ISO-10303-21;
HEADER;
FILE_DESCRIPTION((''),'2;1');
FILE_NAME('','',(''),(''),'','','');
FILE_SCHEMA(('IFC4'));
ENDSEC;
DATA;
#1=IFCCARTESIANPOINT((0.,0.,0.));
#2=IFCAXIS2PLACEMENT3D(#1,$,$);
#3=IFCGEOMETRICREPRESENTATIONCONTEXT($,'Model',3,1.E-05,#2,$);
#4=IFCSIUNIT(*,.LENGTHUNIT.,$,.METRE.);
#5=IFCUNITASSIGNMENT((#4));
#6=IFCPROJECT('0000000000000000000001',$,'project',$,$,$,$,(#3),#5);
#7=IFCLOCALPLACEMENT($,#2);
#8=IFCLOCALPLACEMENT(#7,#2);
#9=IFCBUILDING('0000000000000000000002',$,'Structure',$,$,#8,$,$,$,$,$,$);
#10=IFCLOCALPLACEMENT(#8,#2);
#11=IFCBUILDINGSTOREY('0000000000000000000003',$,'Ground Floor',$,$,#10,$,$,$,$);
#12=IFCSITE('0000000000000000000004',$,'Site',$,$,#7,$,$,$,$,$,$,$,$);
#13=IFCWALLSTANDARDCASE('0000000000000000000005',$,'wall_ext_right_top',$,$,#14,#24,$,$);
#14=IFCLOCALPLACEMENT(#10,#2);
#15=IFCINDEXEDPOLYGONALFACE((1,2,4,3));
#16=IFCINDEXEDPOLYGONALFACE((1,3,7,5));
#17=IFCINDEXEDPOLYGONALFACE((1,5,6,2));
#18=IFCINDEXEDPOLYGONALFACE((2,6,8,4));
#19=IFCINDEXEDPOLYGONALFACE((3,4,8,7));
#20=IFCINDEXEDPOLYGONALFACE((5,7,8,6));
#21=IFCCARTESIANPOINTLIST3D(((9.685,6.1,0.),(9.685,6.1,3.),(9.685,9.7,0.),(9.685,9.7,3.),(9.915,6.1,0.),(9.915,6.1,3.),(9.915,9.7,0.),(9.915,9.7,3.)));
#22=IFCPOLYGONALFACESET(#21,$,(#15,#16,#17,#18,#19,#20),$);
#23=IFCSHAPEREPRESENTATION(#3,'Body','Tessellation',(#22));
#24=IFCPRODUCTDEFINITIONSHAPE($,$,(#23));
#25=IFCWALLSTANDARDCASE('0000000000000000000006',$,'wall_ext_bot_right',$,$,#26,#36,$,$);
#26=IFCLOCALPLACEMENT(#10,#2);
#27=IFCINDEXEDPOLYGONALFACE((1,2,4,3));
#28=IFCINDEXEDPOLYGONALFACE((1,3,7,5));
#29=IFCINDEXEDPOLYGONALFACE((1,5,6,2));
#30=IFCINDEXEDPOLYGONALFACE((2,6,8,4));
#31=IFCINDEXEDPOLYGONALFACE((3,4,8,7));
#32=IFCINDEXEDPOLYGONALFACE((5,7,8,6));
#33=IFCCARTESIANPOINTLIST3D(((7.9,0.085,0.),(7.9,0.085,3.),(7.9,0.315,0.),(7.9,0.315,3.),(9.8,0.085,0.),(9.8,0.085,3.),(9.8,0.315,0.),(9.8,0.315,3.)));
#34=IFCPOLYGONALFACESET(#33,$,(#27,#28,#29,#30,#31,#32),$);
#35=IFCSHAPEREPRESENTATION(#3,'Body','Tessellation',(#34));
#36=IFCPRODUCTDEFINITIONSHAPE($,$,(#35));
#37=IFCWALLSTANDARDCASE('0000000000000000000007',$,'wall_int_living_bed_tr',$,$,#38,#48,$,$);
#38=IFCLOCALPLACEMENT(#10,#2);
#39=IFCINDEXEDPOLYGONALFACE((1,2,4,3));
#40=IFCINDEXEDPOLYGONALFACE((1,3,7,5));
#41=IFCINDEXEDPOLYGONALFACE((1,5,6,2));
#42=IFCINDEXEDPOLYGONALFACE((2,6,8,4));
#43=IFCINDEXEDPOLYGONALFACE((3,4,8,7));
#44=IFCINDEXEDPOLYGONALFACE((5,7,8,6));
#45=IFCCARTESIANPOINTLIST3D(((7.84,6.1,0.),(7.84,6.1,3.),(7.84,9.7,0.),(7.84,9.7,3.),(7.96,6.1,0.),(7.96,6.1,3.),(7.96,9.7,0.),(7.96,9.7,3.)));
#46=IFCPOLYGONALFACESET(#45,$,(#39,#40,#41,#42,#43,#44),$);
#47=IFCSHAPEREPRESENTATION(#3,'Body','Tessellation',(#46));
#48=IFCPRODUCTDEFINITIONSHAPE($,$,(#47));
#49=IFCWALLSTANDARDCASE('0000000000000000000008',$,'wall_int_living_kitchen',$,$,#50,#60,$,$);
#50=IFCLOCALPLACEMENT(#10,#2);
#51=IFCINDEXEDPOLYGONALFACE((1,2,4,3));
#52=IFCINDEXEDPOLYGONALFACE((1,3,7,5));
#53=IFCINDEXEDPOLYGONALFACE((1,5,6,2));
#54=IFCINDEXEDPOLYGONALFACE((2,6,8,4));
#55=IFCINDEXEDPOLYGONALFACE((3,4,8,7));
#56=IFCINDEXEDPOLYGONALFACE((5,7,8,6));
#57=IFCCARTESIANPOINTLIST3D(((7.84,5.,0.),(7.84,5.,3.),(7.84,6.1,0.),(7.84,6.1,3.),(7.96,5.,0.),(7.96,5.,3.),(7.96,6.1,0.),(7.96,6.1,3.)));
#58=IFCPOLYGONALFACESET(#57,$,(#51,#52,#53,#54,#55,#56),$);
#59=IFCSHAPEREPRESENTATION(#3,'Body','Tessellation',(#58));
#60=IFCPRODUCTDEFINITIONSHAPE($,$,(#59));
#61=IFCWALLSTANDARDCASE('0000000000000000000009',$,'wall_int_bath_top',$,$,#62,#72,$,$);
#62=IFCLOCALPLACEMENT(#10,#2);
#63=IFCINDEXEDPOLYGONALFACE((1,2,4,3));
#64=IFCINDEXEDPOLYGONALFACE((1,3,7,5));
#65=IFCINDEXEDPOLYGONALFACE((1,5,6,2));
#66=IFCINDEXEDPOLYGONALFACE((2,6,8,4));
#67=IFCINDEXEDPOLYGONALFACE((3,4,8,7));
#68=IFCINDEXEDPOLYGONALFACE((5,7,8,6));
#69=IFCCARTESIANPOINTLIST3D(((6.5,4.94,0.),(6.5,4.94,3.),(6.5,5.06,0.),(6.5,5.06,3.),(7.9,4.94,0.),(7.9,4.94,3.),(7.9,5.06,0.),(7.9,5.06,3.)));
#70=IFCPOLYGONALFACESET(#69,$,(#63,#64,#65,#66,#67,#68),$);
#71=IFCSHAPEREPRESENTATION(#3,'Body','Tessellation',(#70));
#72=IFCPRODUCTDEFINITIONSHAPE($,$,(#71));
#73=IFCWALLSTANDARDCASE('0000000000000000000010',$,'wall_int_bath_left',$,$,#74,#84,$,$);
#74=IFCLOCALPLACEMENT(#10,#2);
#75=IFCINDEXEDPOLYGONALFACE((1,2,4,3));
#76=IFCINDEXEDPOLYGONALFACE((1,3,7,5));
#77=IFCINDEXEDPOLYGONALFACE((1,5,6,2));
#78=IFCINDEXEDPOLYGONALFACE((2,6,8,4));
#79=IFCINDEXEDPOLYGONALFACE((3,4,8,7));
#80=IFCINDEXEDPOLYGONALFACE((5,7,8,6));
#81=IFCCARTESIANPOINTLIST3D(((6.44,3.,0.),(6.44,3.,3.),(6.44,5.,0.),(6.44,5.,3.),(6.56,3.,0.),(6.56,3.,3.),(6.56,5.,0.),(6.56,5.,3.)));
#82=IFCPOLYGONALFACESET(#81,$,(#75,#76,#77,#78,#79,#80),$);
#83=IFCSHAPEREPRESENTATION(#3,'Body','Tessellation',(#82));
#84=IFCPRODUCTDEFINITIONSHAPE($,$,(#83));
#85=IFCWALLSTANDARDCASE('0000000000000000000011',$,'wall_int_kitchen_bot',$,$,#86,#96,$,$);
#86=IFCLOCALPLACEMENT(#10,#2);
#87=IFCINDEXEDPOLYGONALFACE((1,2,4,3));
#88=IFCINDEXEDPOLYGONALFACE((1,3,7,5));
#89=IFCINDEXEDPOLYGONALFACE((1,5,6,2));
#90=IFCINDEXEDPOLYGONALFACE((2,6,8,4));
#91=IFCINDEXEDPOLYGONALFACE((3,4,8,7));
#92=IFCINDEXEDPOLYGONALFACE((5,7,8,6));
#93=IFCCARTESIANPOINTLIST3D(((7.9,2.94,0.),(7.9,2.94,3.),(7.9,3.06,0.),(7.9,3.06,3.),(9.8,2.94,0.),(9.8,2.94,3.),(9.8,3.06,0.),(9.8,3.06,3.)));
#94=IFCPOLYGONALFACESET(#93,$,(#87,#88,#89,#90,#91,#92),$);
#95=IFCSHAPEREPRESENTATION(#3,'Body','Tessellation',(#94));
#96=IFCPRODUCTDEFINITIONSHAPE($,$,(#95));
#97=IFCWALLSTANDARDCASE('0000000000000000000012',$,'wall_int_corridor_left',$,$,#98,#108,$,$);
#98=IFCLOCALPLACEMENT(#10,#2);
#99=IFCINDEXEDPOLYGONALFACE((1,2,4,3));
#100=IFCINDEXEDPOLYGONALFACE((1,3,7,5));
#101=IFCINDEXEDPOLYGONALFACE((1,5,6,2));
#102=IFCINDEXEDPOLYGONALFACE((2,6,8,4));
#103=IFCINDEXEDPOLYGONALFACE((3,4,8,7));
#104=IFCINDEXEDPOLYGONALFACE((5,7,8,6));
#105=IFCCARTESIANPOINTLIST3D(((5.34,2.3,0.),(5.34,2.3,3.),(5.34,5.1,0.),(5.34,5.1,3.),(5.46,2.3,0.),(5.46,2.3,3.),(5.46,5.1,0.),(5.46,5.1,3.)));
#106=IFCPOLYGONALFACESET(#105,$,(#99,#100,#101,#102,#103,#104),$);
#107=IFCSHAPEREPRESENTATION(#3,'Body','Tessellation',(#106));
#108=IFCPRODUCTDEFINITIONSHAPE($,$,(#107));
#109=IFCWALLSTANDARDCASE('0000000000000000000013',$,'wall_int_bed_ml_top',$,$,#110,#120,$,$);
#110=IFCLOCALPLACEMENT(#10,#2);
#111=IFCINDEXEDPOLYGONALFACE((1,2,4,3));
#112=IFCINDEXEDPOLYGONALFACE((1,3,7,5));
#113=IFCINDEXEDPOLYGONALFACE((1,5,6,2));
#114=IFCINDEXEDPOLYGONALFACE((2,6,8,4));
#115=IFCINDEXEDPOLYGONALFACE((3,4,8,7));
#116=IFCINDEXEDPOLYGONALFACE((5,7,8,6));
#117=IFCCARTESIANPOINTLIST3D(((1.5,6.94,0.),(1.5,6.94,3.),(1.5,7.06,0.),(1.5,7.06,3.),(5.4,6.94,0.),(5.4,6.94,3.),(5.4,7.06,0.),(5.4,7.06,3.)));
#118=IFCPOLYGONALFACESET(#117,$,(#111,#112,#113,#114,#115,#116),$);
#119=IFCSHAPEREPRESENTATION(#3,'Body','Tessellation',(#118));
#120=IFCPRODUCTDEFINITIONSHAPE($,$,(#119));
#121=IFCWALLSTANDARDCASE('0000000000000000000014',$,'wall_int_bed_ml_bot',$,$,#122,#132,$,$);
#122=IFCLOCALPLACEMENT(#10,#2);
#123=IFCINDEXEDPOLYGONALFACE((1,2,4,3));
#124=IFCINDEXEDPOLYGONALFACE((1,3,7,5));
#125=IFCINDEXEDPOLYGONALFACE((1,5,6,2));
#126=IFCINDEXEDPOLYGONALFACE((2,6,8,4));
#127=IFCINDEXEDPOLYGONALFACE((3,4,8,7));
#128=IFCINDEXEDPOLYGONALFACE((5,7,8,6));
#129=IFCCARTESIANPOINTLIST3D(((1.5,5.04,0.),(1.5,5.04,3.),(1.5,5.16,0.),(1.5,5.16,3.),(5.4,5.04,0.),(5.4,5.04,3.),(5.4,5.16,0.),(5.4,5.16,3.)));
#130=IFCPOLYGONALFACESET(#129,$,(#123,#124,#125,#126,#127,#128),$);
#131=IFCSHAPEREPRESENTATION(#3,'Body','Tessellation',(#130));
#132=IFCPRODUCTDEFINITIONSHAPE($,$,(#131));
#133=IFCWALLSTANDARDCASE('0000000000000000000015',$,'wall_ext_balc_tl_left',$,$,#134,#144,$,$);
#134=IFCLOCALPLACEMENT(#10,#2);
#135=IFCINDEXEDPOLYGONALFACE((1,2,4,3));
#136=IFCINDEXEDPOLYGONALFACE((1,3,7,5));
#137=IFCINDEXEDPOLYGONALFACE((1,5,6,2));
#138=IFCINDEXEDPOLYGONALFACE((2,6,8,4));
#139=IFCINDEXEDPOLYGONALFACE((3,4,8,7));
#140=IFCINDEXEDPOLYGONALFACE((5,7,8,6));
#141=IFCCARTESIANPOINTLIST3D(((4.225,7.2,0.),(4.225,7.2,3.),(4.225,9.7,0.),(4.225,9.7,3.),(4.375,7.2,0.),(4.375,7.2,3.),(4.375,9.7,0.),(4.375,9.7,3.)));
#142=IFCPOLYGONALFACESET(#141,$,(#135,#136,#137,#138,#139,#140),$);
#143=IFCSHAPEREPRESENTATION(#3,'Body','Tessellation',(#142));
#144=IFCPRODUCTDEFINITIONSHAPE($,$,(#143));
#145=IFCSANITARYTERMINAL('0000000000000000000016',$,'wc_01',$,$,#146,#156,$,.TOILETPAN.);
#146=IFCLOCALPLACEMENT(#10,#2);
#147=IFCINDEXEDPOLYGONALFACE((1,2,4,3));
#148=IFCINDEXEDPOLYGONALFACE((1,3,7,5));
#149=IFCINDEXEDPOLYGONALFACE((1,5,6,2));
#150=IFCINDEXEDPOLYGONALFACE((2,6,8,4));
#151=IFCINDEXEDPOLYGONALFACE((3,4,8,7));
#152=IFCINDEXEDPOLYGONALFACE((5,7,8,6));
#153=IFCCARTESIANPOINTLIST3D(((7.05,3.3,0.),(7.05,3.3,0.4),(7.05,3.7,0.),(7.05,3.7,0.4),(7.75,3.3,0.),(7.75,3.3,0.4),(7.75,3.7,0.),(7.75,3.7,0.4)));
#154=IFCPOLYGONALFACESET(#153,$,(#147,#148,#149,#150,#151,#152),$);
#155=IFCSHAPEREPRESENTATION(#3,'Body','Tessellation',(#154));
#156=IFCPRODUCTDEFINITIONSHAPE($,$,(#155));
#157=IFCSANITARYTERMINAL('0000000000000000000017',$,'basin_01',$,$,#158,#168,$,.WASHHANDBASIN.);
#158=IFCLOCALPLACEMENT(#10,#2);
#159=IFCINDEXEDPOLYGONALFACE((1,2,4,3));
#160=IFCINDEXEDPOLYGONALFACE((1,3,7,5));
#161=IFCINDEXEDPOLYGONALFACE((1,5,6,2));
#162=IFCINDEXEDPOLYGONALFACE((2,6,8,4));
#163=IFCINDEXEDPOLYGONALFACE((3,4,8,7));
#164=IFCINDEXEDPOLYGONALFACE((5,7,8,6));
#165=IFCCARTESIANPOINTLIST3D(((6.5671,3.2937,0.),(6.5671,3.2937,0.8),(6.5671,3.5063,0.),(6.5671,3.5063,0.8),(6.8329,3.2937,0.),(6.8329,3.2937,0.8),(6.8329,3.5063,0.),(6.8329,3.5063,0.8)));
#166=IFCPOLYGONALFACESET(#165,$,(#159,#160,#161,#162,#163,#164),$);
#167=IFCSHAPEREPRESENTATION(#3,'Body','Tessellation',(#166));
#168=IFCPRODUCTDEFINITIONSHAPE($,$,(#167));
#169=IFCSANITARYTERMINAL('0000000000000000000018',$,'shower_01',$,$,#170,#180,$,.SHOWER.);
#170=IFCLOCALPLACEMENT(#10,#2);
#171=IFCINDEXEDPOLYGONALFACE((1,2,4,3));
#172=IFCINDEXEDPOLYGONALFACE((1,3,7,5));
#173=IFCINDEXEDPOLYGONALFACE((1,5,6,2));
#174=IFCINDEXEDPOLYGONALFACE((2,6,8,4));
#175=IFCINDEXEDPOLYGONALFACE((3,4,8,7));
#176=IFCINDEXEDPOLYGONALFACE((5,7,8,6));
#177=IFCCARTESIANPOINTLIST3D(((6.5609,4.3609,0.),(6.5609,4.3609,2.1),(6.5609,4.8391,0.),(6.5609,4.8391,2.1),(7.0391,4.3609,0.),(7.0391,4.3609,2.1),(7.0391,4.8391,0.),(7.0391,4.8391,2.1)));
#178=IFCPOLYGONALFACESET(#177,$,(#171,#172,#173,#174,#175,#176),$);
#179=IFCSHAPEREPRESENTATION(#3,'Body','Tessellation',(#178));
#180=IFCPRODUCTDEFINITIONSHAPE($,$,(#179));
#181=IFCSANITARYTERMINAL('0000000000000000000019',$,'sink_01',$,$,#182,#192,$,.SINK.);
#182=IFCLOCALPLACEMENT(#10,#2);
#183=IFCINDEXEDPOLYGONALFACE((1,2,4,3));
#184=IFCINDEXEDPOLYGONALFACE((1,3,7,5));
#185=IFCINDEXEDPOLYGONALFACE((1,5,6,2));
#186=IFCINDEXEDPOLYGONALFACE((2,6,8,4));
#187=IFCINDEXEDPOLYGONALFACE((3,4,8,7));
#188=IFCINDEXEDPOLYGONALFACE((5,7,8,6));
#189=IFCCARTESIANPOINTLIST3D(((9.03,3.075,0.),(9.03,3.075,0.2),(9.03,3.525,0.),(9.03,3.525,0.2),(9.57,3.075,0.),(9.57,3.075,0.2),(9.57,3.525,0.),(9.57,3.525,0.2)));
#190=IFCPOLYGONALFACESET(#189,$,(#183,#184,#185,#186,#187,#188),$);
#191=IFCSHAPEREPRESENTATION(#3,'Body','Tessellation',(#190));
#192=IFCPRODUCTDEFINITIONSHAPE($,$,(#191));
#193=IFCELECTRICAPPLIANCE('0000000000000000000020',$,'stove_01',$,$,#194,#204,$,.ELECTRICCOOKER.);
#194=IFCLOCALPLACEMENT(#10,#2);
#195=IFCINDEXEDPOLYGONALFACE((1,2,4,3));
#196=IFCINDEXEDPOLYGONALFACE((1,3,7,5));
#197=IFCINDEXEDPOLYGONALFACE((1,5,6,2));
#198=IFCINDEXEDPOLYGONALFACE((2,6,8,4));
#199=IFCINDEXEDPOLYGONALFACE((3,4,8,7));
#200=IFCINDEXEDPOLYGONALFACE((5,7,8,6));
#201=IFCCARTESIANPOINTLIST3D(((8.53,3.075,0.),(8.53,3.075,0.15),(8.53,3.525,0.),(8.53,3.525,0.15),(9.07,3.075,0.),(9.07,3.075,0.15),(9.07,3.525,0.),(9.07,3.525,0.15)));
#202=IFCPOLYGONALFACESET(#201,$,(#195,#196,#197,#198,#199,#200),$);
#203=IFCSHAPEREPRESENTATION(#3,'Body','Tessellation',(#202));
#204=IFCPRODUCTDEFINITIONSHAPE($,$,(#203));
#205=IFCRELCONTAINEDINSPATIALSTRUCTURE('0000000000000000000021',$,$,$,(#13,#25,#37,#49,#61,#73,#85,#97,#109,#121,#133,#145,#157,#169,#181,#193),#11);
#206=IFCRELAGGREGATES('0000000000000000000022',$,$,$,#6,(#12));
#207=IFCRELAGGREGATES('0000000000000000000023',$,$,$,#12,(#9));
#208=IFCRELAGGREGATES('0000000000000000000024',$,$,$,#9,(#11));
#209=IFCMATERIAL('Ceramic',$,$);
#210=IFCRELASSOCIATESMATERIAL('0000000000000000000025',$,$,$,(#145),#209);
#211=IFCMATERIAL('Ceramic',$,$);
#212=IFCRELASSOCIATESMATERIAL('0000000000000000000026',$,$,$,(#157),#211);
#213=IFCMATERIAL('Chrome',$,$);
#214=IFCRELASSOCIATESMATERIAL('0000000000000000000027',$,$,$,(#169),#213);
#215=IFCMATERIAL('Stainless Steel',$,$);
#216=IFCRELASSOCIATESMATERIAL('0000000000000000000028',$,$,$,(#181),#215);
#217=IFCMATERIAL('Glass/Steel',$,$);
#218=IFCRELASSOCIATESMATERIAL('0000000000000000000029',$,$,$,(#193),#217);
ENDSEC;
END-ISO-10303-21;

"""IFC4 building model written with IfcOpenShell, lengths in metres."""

from ifc_helpers import new_model, si_unit, frame, origin, place, context, project, spatial, polyline, outline, extrude, material, element, save


model = new_model("IFC4")

# Units and contexts
model_context = context("Model", 3, precision=1e-05, world=origin())
ifc_project = project(units=[si_unit("LENGTHUNIT", "METRE")], contexts=[model_context])

# Site, building, storey
site_placement = place(None, origin())
site = spatial("IfcSite", under=ifc_project, at=site_placement, Name="Site")
building_placement = place(site_placement, origin())
building = spatial("IfcBuilding", under=site, at=building_placement, Name="Structure")
storey_placement = place(building_placement, origin())
storey = spatial("IfcBuildingStorey", under=building, at=storey_placement, Name="Ground Floor")

# Walls
wall_1_placement = place(storey_placement, frame((9.8, 6.1, 0.0), x_axis=(0.0, 1.0, 0.0)))
element("IfcWallStandardCase", 1, at=wall_1_placement, inside=storey, Name="wall_ext_right_top", context=model_context, shape_type="SweptSolid", body=[
    extrude(outline(polyline([(0.0, -0.115), (3.6, -0.115), (3.6, 0.115), (0.0, 0.115), (0.0, -0.115)])), origin(), (0.0, 0.0, 1.0), 3.0),
])
wall_2_placement = place(storey_placement, frame((7.9, 0.2, 0.0), x_axis=(1.0, 0.0, 0.0)))
element("IfcWallStandardCase", 2, at=wall_2_placement, inside=storey, Name="wall_ext_bot_right", context=model_context, shape_type="SweptSolid", body=[
    extrude(outline(polyline([(0.0, -0.115), (1.9, -0.115), (1.9, 0.115), (0.0, 0.115), (0.0, -0.115)])), origin(), (0.0, 0.0, 1.0), 3.0),
])
wall_3_placement = place(storey_placement, frame((7.9, 6.1, 0.0), x_axis=(0.0, 1.0, 0.0)))
element("IfcWallStandardCase", 3, at=wall_3_placement, inside=storey, Name="wall_int_living_bed_tr", context=model_context, shape_type="SweptSolid", body=[
    extrude(outline(polyline([(0.0, -0.06), (3.6, -0.06), (3.6, 0.06), (0.0, 0.06), (0.0, -0.06)])), origin(), (0.0, 0.0, 1.0), 3.0),
])
wall_4_placement = place(storey_placement, frame((7.9, 5.0, 0.0), x_axis=(0.0, 1.0, 0.0)))
element("IfcWallStandardCase", 4, at=wall_4_placement, inside=storey, Name="wall_int_living_kitchen", context=model_context, shape_type="SweptSolid", body=[
    extrude(outline(polyline([(0.0, -0.06), (1.1, -0.06), (1.1, 0.06), (0.0, 0.06), (0.0, -0.06)])), origin(), (0.0, 0.0, 1.0), 3.0),
])
wall_5_placement = place(storey_placement, frame((6.5, 5.0, 0.0), x_axis=(1.0, 0.0, 0.0)))
element("IfcWallStandardCase", 5, at=wall_5_placement, inside=storey, Name="wall_int_bath_top", context=model_context, shape_type="SweptSolid", body=[
    extrude(outline(polyline([(0.0, -0.06), (1.4, -0.06), (1.4, 0.06), (0.0, 0.06), (0.0, -0.06)])), origin(), (0.0, 0.0, 1.0), 3.0),
])
wall_6_placement = place(storey_placement, frame((6.5, 3.0, 0.0), x_axis=(0.0, 1.0, 0.0)))
element("IfcWallStandardCase", 6, at=wall_6_placement, inside=storey, Name="wall_int_bath_left", context=model_context, shape_type="SweptSolid", body=[
    extrude(outline(polyline([(0.0, -0.06), (2.0, -0.06), (2.0, 0.06), (0.0, 0.06), (0.0, -0.06)])), origin(), (0.0, 0.0, 1.0), 3.0),
])
wall_7_placement = place(storey_placement, frame((7.9, 3.0, 0.0), x_axis=(1.0, 0.0, 0.0)))
element("IfcWallStandardCase", 7, at=wall_7_placement, inside=storey, Name="wall_int_kitchen_bot", context=model_context, shape_type="SweptSolid", body=[
    extrude(outline(polyline([(0.0, -0.06), (1.9, -0.06), (1.9, 0.06), (0.0, 0.06), (0.0, -0.06)])), origin(), (0.0, 0.0, 1.0), 3.0),
])
wall_8_placement = place(storey_placement, frame((5.4, 2.3, 0.0), x_axis=(0.0, 1.0, 0.0)))
element("IfcWallStandardCase", 8, at=wall_8_placement, inside=storey, Name="wall_int_corridor_left", context=model_context, shape_type="SweptSolid", body=[
    extrude(outline(polyline([(0.0, -0.06), (2.8, -0.06), (2.8, 0.06), (0.0, 0.06), (0.0, -0.06)])), origin(), (0.0, 0.0, 1.0), 3.0),
])
for number, where, x_axis, name in (
    (9, (1.5, 7.0, 0.0), (1.0, 0.0, 0.0), "wall_int_bed_ml_top"),
    (10, (1.5, 5.1, 0.0), (1.0, 0.0, 0.0), "wall_int_bed_ml_bot"),
):
    element("IfcWallStandardCase", number, at=place(storey_placement, frame(where, x_axis=x_axis)), inside=storey, Name=name, context=model_context, shape_type="SweptSolid", body=[
        extrude(outline(polyline([(0.0, -0.06), (3.9, -0.06), (3.9, 0.06), (0.0, 0.06), (0.0, -0.06)])), origin(), (0.0, 0.0, 1.0), 3.0),
    ])
wall_9_placement = place(storey_placement, frame((4.3, 7.2, 0.0), x_axis=(0.0, 1.0, 0.0)))
element("IfcWallStandardCase", 11, at=wall_9_placement, inside=storey, Name="wall_ext_balc_tl_left", context=model_context, shape_type="SweptSolid", body=[
    extrude(outline(polyline([(0.0, -0.075), (2.5, -0.075), (2.5, 0.075), (0.0, 0.075), (0.0, -0.075)])), origin(), (0.0, 0.0, 1.0), 3.0),
])

# Sanitary terminals
ifc_material_1 = material(Name="Ceramic")
sanitary_terminal_1_placement = place(storey_placement, frame((7.4, 3.5, 0.0)))
element("IfcSanitaryTerminal", 12, at=sanitary_terminal_1_placement, inside=storey, material=ifc_material_1, Name="wc_01", PredefinedType="TOILETPAN", context=model_context, shape_type="SweptSolid", body=[
    extrude(outline(polyline([(-0.35, -0.2), (0.35, -0.2), (0.35, 0.2), (-0.35, 0.2), (-0.35, -0.2)])), origin(), (0.0, 0.0, 1.0), 0.4),
])
ifc_material_2 = material(Name="Ceramic")
sanitary_terminal_2_placement = place(storey_placement, frame((6.7, 3.4, 0.0)))
element("IfcSanitaryTerminal", 13, at=sanitary_terminal_2_placement, inside=storey, material=ifc_material_2, Name="basin_01", PredefinedType="WASHHANDBASIN", context=model_context, shape_type="SweptSolid", body=[
    extrude(outline(polyline([(-0.1329, -0.1063), (0.1329, -0.1063), (0.1329, 0.1063), (-0.1329, 0.1063), (-0.1329, -0.1063)])), origin(), (0.0, 0.0, 1.0), 0.8),
])
ifc_material_3 = material(Name="Chrome")
sanitary_terminal_3_placement = place(storey_placement, frame((6.8, 4.6, 0.0)))
element("IfcSanitaryTerminal", 14, at=sanitary_terminal_3_placement, inside=storey, material=ifc_material_3, Name="shower_01", PredefinedType="SHOWER", context=model_context, shape_type="SweptSolid", body=[
    extrude(outline(polyline([(-0.2391, -0.2391), (0.2391, -0.2391), (0.2391, 0.2391), (-0.2391, 0.2391), (-0.2391, -0.2391)])), origin(), (0.0, 0.0, 1.0), 2.1),
])
ifc_material_4 = material(Name="Stainless Steel")
sanitary_terminal_4_placement = place(storey_placement, frame((9.3, 3.3, 0.0)))
element("IfcSanitaryTerminal", 15, at=sanitary_terminal_4_placement, inside=storey, material=ifc_material_4, Name="sink_01", PredefinedType="SINK", context=model_context, shape_type="SweptSolid", body=[
    extrude(outline(polyline([(-0.27, -0.225), (0.27, -0.225), (0.27, 0.225), (-0.27, 0.225), (-0.27, -0.225)])), origin(), (0.0, 0.0, 1.0), 0.2),
])

# Electric appliance
ifc_material_5 = material(Name="Glass/Steel")
electric_appliance_placement = place(storey_placement, frame((8.8, 3.3, 0.0)))
element("IfcElectricAppliance", 16, at=electric_appliance_placement, inside=storey, material=ifc_material_5, Name="stove_01", PredefinedType="ELECTRICCOOKER", context=model_context, shape_type="SweptSolid", body=[
    extrude(outline(polyline([(-0.27, -0.225), (0.27, -0.225), (0.27, 0.225), (-0.27, 0.225), (-0.27, -0.225)])), origin(), (0.0, 0.0, 1.0), 0.15),
])

save(model, "model.ifc")
